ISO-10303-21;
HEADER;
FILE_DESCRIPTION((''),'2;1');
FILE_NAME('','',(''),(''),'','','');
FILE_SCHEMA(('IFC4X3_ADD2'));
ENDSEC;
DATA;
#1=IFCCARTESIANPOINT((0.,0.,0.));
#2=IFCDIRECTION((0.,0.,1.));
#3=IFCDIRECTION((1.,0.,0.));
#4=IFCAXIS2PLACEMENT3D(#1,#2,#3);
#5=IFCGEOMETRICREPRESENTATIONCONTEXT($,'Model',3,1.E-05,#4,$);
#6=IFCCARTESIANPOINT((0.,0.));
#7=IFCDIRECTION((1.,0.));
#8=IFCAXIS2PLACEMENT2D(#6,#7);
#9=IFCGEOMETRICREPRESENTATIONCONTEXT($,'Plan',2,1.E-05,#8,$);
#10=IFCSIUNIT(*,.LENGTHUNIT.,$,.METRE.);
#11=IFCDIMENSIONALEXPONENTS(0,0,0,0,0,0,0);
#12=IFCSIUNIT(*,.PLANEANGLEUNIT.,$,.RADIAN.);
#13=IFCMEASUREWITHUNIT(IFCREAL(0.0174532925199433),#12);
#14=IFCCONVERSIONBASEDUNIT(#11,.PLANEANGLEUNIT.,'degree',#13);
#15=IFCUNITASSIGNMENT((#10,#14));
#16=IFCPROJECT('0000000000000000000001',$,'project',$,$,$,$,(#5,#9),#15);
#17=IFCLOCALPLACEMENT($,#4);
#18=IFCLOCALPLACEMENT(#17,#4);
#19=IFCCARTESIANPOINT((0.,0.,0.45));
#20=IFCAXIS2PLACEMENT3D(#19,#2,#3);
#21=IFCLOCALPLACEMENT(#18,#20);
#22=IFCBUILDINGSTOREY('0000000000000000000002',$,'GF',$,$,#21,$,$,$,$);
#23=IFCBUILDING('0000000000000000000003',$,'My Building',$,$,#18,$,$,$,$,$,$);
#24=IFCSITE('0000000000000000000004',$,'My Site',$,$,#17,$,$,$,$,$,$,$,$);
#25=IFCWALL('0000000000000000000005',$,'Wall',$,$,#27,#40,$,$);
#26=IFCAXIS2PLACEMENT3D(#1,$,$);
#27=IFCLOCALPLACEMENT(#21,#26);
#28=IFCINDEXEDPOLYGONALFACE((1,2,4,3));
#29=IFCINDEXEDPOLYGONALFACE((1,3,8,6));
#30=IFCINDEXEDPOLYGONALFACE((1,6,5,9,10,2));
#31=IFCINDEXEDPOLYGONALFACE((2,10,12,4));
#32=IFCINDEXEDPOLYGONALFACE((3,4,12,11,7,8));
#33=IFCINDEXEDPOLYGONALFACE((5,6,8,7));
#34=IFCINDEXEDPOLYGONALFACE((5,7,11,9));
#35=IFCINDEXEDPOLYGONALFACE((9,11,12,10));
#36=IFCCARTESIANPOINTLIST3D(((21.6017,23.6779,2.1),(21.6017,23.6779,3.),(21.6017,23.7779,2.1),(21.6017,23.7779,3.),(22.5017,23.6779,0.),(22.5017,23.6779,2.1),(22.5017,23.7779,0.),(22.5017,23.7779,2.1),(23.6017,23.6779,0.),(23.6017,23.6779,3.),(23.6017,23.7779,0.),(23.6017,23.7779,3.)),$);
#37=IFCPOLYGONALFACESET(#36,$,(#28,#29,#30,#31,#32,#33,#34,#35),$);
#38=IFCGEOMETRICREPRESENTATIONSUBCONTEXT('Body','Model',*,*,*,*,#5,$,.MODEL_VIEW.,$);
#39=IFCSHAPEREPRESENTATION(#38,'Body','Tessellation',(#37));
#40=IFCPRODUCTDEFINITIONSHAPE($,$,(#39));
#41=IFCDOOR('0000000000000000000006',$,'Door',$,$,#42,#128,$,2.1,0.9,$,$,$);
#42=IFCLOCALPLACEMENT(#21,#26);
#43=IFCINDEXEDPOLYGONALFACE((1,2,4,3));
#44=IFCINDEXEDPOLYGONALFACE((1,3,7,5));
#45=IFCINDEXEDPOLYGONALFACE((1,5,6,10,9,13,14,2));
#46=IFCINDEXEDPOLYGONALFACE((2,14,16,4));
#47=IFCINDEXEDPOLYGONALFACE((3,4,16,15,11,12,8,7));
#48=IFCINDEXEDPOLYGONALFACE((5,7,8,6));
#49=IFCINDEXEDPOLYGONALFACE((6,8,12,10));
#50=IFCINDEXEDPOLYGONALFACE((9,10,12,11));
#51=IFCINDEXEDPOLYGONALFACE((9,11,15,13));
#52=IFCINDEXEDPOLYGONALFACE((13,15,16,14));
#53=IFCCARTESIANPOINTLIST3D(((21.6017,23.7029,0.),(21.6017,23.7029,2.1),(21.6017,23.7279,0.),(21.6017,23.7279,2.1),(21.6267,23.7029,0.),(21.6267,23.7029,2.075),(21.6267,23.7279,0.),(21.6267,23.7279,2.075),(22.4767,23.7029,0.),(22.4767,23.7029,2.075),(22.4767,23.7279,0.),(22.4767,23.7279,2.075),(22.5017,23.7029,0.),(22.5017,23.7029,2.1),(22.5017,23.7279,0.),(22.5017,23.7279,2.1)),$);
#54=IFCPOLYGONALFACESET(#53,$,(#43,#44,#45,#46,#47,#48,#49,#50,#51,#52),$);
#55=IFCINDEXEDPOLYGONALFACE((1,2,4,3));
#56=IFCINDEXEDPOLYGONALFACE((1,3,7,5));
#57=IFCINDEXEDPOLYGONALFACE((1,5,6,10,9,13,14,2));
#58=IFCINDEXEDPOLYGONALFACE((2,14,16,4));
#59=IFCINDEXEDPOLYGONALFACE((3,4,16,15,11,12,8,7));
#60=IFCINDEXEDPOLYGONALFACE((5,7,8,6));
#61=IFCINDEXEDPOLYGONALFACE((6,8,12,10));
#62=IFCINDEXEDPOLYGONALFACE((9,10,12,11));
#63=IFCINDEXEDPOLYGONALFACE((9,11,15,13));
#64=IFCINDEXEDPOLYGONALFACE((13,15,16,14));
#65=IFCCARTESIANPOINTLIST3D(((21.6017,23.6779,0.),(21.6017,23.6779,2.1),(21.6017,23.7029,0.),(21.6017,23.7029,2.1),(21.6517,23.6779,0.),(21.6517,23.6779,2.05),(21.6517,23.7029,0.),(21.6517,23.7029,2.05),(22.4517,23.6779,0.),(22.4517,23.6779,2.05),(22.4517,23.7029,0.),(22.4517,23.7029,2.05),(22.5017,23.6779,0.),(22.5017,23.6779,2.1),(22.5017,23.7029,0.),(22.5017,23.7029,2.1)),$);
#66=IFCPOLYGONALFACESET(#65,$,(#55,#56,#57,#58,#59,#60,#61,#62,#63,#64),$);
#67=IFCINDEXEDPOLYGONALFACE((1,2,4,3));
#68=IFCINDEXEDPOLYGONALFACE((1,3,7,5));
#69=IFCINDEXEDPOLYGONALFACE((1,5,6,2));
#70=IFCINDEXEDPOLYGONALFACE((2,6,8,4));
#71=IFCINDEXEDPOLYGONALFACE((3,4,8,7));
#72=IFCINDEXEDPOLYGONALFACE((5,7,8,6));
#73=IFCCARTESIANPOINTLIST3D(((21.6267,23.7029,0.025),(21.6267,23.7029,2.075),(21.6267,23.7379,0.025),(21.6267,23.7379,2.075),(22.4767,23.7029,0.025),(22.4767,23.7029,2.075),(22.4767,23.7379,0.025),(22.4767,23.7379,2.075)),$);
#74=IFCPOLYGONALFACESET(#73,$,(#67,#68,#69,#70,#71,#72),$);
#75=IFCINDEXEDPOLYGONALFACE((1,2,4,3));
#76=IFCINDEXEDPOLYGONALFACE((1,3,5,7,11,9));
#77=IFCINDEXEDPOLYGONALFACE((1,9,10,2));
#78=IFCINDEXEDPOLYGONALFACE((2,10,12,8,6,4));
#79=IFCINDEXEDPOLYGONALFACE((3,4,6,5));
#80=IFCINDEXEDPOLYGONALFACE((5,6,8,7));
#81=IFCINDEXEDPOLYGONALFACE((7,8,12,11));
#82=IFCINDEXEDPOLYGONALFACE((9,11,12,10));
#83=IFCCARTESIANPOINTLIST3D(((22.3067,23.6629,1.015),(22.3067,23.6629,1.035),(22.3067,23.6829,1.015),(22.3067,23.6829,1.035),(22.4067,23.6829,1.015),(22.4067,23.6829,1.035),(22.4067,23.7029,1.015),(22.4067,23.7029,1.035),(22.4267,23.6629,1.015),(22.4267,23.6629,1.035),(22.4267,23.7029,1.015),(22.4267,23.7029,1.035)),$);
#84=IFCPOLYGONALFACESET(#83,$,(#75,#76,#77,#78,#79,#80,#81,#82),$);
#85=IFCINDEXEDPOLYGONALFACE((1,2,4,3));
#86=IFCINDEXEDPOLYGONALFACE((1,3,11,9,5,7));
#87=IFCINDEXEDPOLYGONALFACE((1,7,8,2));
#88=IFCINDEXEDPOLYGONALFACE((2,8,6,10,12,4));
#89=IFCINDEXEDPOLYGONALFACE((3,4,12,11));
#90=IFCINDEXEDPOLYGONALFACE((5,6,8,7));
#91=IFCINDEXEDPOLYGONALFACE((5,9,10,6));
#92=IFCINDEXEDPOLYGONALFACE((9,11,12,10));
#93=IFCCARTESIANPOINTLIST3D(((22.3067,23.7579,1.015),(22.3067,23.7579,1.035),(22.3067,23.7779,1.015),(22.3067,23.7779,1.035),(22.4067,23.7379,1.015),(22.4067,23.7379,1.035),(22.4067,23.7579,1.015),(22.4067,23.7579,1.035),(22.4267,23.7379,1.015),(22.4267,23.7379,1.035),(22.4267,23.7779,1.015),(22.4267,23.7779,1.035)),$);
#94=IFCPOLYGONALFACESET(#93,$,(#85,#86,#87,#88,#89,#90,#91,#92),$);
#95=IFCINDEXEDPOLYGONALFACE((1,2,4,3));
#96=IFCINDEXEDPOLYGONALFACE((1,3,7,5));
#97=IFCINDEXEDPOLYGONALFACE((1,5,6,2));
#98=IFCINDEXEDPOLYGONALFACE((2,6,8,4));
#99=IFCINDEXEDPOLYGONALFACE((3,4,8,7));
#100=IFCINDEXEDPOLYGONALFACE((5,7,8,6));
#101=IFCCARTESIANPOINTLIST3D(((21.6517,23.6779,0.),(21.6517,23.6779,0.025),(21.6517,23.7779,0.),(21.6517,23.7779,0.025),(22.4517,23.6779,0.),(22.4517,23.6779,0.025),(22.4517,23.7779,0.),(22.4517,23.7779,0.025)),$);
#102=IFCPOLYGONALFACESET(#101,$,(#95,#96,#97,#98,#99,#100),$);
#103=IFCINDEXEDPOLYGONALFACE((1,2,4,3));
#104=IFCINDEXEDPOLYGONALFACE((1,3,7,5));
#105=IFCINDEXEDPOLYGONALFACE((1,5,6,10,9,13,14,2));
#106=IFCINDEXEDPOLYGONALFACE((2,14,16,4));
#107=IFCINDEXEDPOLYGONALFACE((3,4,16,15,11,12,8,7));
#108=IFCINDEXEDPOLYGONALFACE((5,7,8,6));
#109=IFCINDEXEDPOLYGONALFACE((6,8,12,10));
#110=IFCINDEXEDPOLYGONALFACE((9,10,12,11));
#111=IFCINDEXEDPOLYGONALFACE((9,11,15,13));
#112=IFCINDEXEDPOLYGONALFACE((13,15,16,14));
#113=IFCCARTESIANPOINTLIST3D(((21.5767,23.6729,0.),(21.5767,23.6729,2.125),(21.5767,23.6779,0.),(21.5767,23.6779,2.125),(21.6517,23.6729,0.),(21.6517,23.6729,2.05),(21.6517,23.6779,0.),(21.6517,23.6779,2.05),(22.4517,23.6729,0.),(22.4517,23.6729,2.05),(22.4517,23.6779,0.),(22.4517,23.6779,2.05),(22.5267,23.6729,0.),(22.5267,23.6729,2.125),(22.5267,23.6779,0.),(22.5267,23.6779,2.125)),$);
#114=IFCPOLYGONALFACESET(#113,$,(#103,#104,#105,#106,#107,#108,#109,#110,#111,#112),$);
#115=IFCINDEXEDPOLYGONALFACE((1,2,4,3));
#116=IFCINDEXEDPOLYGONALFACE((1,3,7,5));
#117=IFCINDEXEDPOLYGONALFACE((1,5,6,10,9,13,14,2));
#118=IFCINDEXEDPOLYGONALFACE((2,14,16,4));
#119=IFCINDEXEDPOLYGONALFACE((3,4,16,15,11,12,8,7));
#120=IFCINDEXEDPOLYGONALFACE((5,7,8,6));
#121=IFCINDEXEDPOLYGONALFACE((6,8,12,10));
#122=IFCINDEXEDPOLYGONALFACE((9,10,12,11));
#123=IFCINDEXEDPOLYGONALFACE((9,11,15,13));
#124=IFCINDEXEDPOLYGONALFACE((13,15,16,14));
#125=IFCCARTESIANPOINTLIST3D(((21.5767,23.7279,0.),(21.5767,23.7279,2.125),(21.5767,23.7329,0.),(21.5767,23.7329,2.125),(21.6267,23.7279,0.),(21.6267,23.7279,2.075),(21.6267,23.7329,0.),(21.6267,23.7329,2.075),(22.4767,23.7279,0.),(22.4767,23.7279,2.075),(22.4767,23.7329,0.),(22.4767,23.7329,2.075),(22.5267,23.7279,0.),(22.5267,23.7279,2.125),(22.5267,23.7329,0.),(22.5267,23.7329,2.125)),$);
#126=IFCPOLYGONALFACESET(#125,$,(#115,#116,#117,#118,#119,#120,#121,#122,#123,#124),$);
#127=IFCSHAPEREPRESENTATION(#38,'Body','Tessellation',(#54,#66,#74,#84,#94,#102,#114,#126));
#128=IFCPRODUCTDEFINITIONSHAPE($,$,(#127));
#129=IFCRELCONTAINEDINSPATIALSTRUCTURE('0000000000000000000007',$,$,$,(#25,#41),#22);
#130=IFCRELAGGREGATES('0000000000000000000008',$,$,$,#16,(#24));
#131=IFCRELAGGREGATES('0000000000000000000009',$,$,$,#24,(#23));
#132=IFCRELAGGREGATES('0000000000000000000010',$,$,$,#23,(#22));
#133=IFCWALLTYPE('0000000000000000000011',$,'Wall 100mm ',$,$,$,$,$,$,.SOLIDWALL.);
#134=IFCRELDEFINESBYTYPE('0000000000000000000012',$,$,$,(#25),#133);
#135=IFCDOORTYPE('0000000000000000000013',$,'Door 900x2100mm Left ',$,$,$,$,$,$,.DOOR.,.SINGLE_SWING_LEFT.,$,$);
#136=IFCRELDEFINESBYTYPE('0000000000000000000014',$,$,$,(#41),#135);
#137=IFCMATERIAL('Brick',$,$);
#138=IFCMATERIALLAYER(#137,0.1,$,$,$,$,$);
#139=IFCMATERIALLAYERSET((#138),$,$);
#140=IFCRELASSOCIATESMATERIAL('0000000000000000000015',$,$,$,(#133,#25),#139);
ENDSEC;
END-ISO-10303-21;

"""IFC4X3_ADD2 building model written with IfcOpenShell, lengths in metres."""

from ifc_helpers import new_model, entity, si_unit, converted_unit, frame, origin_with_axes, origin_2d_with_axis, place, context, subcontext, project, spatial, line, indexed_curve, outline, extrude, shape, source, transform, mapped, material, layer, layer_set, layer_usage, type_object, type_shapes, element, fill, save


model = new_model("IFC4X3_ADD2")

# Units and contexts
model_context = context("Model", 3, precision=1e-05, world=origin_with_axes())
plan_context = context("Plan", 2, precision=1e-05, world=origin_2d_with_axis())
body_context_1 = subcontext(model_context, "Body", "Model", "MODEL_VIEW")
body_context_2 = subcontext(plan_context, "Body", "Plan", "PLAN_VIEW")
ifc_project = project(units=[si_unit("LENGTHUNIT", "METRE"), converted_unit("PLANEANGLEUNIT", "degree", entity("IfcReal", 0.0174532925199433), si_unit("PLANEANGLEUNIT", "RADIAN"), dimensions=[0, 0, 0, 0, 0, 0, 0])], contexts=[model_context, plan_context])

# Site, building, storey
site_placement = place(None, origin_with_axes())
site = spatial("IfcSite", under=ifc_project, at=site_placement, Name="My Site")
building_placement = place(site_placement, origin_with_axes())
building = spatial("IfcBuilding", under=site, at=building_placement, Name="My Building")
storey_placement = place(building_placement, frame((0.0, 0.0, 0.45), z_axis=(0.0, 0.0, 1.0), x_axis=(1.0, 0.0, 0.0)))
storey = spatial("IfcBuildingStorey", under=building, at=storey_placement, Name="GF")

# Shared definitions
ifc_material = material(Name="Brick")

# Wall, opening, door
ifc_layer_1 = layer(ifc_material, 0.1)
ifc_layer_set_1 = layer_set([ifc_layer_1])
ifc_layer_usage_1 = layer_usage(ifc_layer_set_1, "AXIS2", "POSITIVE", 0.0)
wall_type_1 = type_object("IfcWallType", Name="Wall 100mm ", PredefinedType="SOLIDWALL", material=ifc_layer_set_1)
wall_1_placement = place(storey_placement, frame((21.6017, 23.6779, 0.0), z_axis=(0.0, 0.0, 1.0), x_axis=(1.0, 0.0, 0.0)))
wall_1 = element("IfcWall", 1, at=wall_1_placement, inside=storey, type_object=wall_type_1, material=ifc_layer_usage_1, Name="Wall", context=body_context_1, shape_type="SweptSolid", body=[
    extrude(outline(indexed_curve([(0.0, 0.0), (0.0, 0.1), (2.0, 0.1), (2.0, 0.0), (0.0, 0.0)], self_intersect=False)), origin_with_axes(), (0.0, 0.0, 1.0), 3.0),
])
shared_shape_1 = source(origin_with_axes(), body_context_1, "Body", "SweptSolid", [
    extrude(outline(indexed_curve([(0.0, 0.0), (0.9, 0.0), (0.9, 2.1), (0.0, 2.1)], segments=[line(1, 2, 3, 4, 1)])), frame((0.0, -0.6, 0.0), z_axis=(0.0, -1.0, 0.0), x_axis=(1.0, 0.0, 0.0)), (0.0, 0.0, -1.0), 1.2),
])
opening_1_placement = place(wall_1_placement, frame((0.0, 0.0, 0.0), z_axis=(0.0, 0.0, 1.0), x_axis=(1.0, 0.0, 0.0)))
opening_1 = element("IfcOpeningElement", 2, at=opening_1_placement, cuts=wall_1, PredefinedType="OPENING", context=body_context_1, shape_type="MappedRepresentation", body=[
    mapped(shared_shape_1, transform((0.0, 0.0, 0.0), x_axis=(1.0, 0.0, 0.0), y_axis=(0.0, 1.0, 0.0), z_axis=(0.0, 0.0, 1.0), scale=1.0)),
])
door_type_1 = type_object("IfcDoorType", Name="Door 900x2100mm Left ", OperationType="SINGLE_SWING_LEFT", PredefinedType="DOOR")
shared_shape_2 = source(origin_with_axes(), body_context_1, "Body", "SweptSolid", [
    extrude(outline(indexed_curve([(0.0, 0.0), (0.0, 2.1), (0.9, 2.1), (0.9, 0.0), (0.875, 0.0), (0.875, 2.075), (0.025, 2.075), (0.025, 0.0)], segments=[line(1, 2, 3, 4, 5, 6, 7, 8, 1)])), frame((0.0, 0.025, 0.0), z_axis=(0.0, -1.0, 0.0), x_axis=(1.0, 0.0, 0.0)), (0.0, 0.0, -1.0), 0.025),
    extrude(outline(indexed_curve([(0.0, 0.0), (0.0, 2.1), (0.9, 2.1), (0.9, 0.0), (0.85, 0.0), (0.85, 2.05), (0.05, 2.05), (0.05, 0.0)], segments=[line(1, 2, 3, 4, 5, 6, 7, 8, 1)])), frame((0.0, 0.0, 0.0), z_axis=(0.0, -1.0, 0.0), x_axis=(1.0, 0.0, 0.0)), (0.0, 0.0, -1.0), 0.025),
    extrude(outline(indexed_curve([(0.0, 0.0), (0.85, 0.0), (0.85, 0.035), (0.0, 0.035)], segments=[line(1, 2, 3, 4, 1)])), frame((0.025, 0.025, 0.025), z_axis=(0.0, 0.0, 1.0), x_axis=(1.0, 0.0, 0.0)), (0.0, 0.0, 1.0), 2.05),
    extrude(outline(indexed_curve([(0.0, 0.0), (0.0, -0.04), (-0.12, -0.04), (-0.12, -0.02), (-0.02, -0.02), (-0.02, 0.0)], segments=[line(1, 2, 3, 4, 5, 6, 1)])), frame((0.825, 0.025, 1.015), z_axis=(0.0, 0.0, 1.0), x_axis=(1.0, 0.0, 0.0)), (0.0, 0.0, 1.0), 0.02),
    extrude(outline(indexed_curve([(0.0, 0.0), (0.0, 0.04), (-0.12, 0.04), (-0.12, 0.02), (-0.02, 0.02), (-0.02, 0.0)], segments=[line(1, 2, 3, 4, 5, 6, 1)])), frame((0.825, 0.06, 1.015), z_axis=(0.0, 0.0, 1.0), x_axis=(1.0, 0.0, 0.0)), (0.0, 0.0, 1.0), 0.02),
    extrude(outline(indexed_curve([(0.0, 0.0), (0.8, 0.0), (0.8, 0.1), (0.0, 0.1)], segments=[line(1, 2, 3, 4, 1)])), frame((0.05, 0.0, 0.0), z_axis=(0.0, 0.0, 1.0), x_axis=(1.0, 0.0, 0.0)), (0.0, 0.0, 1.0), 0.025),
    extrude(outline(indexed_curve([(0.0, 0.0), (0.0, 2.125), (0.95, 2.125), (0.95, 0.0), (0.875, 0.0), (0.875, 2.05), (0.075, 2.05), (0.075, 0.0)], segments=[line(1, 2, 3, 4, 5, 6, 7, 8, 1)])), frame((-0.025, -0.005, 0.0), z_axis=(0.0, -1.0, 0.0), x_axis=(1.0, 0.0, 0.0)), (0.0, 0.0, -1.0), 0.005),
    extrude(outline(indexed_curve([(0.0, 0.0), (0.0, 2.125), (0.95, 2.125), (0.95, 0.0), (0.9, 0.0), (0.9, 2.075), (0.05, 2.075), (0.05, 0.0)], segments=[line(1, 2, 3, 4, 5, 6, 7, 8, 1)])), frame((-0.025, 0.05, 0.0), z_axis=(0.0, -1.0, 0.0), x_axis=(1.0, 0.0, 0.0)), (0.0, 0.0, -1.0), 0.005),
])
shared_shape_3 = source(origin_with_axes(), body_context_2, "Body", "Curve2D", [
    entity("IfcIndexedPolyCurve", entity("IfcCartesianPointList2D", [[0.0, 0.0], [0.0, 0.05], [0.025, 0.05], [0.025, 0.025], [0.05, 0.025], [0.05, 0.0]]), [entity("IfcLineIndex", [1, 2, 3, 4, 5, 6, 1])]),
    entity("IfcIndexedPolyCurve", entity("IfcCartesianPointList2D", [[0.9, 0.0], [0.9, 0.05], [0.875, 0.05], [0.875, 0.025], [0.85, 0.025], [0.85, 0.0]]), [entity("IfcLineIndex", [1, 2, 3, 4, 5, 6, 1])]),
    entity("IfcTrimmedCurve", entity("IfcEllipse", entity("IfcAxis2Placement2D", entity("IfcCartesianPoint", [0.06, 0.05]), entity("IfcDirection", [1.0, 0.0])), 0.815, 0.85), [entity("IfcCartesianPoint", [0.875, 0.05])], [entity("IfcCartesianPoint", [0.06, 0.9])], True, "CARTESIAN"),
    entity("IfcIndexedPolyCurve", entity("IfcCartesianPointList2D", [[0.025, 0.05], [0.06, 0.05], [0.06, 0.9], [0.025, 0.9]]), [entity("IfcLineIndex", [1, 2, 3, 4, 1])]),
])
type_shapes(door_type_1, [shared_shape_2, shared_shape_3])
door_1_placement = place(opening_1_placement, origin_with_axes())
door_1 = element("IfcDoor", 3, at=door_1_placement, inside=storey, type_object=door_type_1, Name="Door", OverallHeight=2.1, OverallWidth=0.9, shapes=[
    shape(body_context_1, "Body", "MappedRepresentation", [mapped(shared_shape_2, transform((0.0, 0.0, 0.0), x_axis=(1.0, 0.0, 0.0), y_axis=(0.0, 1.0, 0.0), z_axis=(0.0, 0.0, 1.0), scale=1.0))]),
    shape(body_context_2, "Body", "MappedRepresentation", [mapped(shared_shape_3, transform((0.0, 0.0, 0.0), x_axis=(1.0, 0.0, 0.0), y_axis=(0.0, 1.0, 0.0), z_axis=(0.0, 0.0, 1.0), scale=1.0))]),
])
fill(opening_1, door_1)

save(model, "model.ifc")
